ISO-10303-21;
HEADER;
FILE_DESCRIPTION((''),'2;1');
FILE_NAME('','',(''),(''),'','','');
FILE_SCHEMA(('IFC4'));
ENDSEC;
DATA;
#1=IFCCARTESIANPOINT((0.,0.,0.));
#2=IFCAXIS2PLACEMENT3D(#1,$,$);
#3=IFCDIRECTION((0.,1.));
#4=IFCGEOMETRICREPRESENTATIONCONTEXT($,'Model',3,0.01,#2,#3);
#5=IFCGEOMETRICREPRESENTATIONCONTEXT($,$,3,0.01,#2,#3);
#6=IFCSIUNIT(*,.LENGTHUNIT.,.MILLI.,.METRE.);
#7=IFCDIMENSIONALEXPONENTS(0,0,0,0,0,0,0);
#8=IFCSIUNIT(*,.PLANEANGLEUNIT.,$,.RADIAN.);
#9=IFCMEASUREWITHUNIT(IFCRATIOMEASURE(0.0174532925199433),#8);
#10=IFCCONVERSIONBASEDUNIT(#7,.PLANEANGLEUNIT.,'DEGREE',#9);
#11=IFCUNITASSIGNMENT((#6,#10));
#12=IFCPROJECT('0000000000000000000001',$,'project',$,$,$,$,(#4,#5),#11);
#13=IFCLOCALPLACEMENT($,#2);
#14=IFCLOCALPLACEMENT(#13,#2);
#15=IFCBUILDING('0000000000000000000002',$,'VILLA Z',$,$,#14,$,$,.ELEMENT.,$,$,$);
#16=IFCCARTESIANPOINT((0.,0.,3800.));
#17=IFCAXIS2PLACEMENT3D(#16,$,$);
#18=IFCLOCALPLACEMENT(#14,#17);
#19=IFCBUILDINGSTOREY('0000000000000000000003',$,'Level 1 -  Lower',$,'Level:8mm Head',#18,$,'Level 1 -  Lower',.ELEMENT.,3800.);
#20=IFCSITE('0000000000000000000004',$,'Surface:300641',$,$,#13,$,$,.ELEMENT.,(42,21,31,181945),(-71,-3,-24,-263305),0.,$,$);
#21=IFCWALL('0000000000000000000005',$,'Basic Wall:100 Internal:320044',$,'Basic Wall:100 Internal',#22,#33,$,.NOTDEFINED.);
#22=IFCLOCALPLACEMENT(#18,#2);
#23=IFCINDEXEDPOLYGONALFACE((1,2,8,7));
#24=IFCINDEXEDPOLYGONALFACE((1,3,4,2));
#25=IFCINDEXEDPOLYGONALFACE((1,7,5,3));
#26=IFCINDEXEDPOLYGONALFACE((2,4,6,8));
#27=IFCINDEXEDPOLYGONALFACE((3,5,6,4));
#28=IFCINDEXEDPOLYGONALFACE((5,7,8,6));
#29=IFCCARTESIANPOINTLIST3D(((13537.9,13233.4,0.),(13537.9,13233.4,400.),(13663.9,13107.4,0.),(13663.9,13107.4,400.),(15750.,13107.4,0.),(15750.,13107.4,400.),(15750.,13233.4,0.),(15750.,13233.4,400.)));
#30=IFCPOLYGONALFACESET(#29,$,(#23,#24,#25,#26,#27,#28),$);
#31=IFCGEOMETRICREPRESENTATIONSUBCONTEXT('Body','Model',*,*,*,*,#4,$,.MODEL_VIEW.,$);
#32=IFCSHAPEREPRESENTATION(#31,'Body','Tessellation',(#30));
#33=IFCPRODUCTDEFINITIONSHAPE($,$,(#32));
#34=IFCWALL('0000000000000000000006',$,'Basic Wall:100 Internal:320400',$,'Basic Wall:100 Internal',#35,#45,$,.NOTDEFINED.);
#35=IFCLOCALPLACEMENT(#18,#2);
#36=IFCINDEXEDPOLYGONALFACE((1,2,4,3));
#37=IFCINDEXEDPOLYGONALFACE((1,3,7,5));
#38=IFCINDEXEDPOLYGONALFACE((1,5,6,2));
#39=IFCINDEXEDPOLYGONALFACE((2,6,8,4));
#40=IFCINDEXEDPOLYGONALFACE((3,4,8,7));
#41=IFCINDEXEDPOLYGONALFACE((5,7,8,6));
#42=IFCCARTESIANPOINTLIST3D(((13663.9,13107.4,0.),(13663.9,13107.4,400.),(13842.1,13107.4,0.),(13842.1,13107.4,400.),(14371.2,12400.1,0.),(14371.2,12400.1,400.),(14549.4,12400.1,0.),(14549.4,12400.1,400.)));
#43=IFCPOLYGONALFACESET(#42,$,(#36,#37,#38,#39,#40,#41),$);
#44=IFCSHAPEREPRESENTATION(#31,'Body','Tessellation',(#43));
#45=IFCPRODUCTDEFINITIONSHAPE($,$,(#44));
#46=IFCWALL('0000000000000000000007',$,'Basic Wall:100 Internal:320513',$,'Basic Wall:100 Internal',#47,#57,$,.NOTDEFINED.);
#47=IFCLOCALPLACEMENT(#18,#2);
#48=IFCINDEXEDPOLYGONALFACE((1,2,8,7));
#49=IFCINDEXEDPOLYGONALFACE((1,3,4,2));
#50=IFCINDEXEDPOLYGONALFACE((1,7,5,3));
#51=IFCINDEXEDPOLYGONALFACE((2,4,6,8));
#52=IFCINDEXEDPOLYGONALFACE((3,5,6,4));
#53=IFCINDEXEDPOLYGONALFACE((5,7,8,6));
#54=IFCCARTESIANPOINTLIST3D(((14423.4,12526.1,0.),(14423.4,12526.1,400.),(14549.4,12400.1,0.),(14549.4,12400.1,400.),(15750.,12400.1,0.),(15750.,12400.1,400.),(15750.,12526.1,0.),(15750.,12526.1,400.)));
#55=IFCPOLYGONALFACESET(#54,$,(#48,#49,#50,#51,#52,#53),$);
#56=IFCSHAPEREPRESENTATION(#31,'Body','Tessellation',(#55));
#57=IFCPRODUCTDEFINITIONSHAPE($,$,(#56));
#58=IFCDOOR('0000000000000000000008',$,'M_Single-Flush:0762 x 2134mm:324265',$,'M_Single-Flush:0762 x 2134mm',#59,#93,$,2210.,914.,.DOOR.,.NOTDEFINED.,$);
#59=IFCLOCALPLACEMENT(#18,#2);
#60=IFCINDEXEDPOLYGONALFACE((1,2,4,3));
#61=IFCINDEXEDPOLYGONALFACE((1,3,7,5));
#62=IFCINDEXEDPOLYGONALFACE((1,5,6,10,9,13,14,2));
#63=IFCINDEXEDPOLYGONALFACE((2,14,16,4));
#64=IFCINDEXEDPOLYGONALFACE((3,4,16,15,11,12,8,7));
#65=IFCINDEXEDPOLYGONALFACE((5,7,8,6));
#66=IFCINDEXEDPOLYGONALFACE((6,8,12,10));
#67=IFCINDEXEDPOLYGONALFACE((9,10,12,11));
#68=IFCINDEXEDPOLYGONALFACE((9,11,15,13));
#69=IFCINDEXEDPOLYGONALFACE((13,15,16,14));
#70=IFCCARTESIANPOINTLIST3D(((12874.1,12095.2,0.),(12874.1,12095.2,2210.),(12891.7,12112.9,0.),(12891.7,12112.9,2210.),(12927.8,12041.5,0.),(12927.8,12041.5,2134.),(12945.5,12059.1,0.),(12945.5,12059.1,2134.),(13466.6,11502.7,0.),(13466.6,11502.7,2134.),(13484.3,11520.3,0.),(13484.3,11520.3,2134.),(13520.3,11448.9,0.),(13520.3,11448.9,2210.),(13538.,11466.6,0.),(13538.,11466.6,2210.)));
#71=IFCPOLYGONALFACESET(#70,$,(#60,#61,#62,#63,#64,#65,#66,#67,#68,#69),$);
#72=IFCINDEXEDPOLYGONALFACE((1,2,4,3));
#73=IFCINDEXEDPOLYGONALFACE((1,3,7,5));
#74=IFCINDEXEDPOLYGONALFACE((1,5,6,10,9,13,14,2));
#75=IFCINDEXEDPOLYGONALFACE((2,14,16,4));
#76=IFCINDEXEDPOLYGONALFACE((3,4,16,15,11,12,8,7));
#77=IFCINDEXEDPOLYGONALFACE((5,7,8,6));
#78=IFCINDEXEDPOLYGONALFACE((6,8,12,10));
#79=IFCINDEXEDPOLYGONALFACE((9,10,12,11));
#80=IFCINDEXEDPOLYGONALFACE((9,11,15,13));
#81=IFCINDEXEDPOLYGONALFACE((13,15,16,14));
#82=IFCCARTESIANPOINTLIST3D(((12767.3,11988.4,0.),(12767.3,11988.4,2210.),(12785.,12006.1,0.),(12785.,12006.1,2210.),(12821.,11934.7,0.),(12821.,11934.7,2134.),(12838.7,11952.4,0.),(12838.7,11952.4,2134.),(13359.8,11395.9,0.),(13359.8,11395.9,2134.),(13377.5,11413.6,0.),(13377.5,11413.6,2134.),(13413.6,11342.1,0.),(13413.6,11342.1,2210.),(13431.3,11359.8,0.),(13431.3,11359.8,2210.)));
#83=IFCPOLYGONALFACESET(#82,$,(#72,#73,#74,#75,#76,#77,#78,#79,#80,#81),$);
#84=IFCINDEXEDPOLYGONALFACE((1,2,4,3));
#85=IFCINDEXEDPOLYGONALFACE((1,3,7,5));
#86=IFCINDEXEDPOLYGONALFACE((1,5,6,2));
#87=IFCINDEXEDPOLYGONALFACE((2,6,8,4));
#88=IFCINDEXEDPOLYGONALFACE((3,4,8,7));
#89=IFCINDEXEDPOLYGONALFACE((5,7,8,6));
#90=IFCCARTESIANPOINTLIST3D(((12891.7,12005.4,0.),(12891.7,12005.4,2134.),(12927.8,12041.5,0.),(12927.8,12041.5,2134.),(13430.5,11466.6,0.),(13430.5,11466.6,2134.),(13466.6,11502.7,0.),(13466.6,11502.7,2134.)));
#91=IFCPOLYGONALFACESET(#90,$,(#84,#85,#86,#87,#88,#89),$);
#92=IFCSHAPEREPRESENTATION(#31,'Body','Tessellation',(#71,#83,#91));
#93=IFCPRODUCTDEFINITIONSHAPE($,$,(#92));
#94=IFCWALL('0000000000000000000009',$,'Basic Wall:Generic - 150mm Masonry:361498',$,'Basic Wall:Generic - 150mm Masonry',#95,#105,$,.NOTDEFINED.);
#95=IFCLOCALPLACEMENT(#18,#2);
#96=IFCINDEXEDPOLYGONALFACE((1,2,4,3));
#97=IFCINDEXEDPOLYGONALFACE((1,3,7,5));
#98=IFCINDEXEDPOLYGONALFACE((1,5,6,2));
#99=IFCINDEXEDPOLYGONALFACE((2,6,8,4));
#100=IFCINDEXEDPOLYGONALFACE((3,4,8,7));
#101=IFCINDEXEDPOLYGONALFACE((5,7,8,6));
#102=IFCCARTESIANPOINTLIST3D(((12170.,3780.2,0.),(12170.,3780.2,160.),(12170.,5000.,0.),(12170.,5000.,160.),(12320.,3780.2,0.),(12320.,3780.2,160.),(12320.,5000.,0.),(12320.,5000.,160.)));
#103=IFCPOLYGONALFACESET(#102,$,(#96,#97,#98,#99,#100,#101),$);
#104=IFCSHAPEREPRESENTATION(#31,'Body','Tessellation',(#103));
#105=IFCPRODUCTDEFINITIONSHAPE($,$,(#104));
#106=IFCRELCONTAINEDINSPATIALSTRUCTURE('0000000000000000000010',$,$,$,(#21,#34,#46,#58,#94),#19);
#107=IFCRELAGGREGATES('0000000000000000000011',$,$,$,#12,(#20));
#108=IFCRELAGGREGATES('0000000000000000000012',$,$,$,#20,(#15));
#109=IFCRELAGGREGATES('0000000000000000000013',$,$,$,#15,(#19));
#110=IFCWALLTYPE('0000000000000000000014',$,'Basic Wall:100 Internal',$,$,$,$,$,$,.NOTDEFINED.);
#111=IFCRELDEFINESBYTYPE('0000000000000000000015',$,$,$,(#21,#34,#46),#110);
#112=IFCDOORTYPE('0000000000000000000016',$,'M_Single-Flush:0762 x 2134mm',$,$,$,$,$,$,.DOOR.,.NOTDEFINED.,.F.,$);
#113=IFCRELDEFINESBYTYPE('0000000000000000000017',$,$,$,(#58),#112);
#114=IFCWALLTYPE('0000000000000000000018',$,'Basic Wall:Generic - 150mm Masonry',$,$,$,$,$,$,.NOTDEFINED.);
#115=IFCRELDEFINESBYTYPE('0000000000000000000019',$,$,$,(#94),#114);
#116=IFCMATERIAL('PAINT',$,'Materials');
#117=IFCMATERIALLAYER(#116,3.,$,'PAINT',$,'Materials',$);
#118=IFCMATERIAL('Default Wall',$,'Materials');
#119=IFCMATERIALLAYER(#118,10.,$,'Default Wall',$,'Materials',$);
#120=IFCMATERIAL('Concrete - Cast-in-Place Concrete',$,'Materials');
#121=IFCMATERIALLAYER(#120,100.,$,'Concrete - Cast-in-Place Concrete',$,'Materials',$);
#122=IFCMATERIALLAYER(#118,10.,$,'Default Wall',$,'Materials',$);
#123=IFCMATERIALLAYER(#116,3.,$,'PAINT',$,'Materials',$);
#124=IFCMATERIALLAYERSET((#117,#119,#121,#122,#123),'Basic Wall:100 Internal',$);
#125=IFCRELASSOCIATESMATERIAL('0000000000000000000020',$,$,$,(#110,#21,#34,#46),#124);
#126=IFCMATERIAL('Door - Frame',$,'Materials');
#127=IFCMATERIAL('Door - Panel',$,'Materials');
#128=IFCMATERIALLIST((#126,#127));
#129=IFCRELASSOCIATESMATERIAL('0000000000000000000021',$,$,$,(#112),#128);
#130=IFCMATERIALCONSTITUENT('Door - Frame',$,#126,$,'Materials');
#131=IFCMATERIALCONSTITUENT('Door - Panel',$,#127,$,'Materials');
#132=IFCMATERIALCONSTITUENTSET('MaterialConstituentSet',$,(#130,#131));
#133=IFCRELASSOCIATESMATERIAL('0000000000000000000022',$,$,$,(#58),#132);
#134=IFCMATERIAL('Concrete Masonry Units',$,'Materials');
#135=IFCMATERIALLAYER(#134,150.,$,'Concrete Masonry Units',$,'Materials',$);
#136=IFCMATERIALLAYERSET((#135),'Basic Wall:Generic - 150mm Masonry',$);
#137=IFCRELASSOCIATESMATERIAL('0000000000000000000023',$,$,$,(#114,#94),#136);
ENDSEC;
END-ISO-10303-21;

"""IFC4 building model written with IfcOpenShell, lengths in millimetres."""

from ifc_helpers import new_model, entity, si_unit, converted_unit, direction, frame, frame_2d, origin, origin_2d_with_axis, place, context, subcontext, project, spatial, polyline, rectangle, outline, extrude, clip, halfspace, source, transform, mapped, material, material_list, layer, layer_set, layer_usage, constituent, constituent_set, type_object, type_shapes, element, save


model = new_model("IFC4")

# Units and contexts
model_context = context("Model", 3, precision=0.01, world=origin(), true_north=direction((0.0, 1.0)))
context_of_model = context(None, 3, precision=0.01, world=origin(), true_north=direction((0.0, 1.0)))
body_context = subcontext(model_context, "Body", "Model", "MODEL_VIEW")
ifc_project = project(units=[si_unit("LENGTHUNIT", "METRE", prefix="MILLI"), converted_unit("PLANEANGLEUNIT", "DEGREE", entity("IfcRatioMeasure", 0.0174532925199433), si_unit("PLANEANGLEUNIT", "RADIAN"), dimensions=[0, 0, 0, 0, 0, 0, 0])], contexts=[model_context, context_of_model])

# Site, building, storey
site_placement = place(None, origin())
site = spatial("IfcSite", under=ifc_project, at=site_placement, Name="Surface:300641", CompositionType="ELEMENT", RefLatitude=(42, 21, 31, 181945), RefLongitude=(-71, -3, -24, -263305), RefElevation=0.0)
building_placement = place(site_placement, origin())
building = spatial("IfcBuilding", under=site, at=building_placement, Name="VILLA Z", CompositionType="ELEMENT")
storey_placement = place(building_placement, frame((0.0, 0.0, 3800.0)))
storey = spatial("IfcBuildingStorey", under=building, at=storey_placement, Name="Level 1 -  Lower", ObjectType="Level:8mm Head", LongName="Level 1 -  Lower", CompositionType="ELEMENT", Elevation=3800.0)

# Shared definitions
ifc_material_1 = material(Name="Concrete - Cast-in-Place Concrete", Category="Materials")

# Shared definitions
ifc_material_2 = material(Name="PAINT", Category="Materials")
ifc_material_3 = material(Name="Default Wall", Category="Materials")

# Walls
ifc_layer_1 = layer(ifc_material_2, 3.0, Name="PAINT", Category="Materials")
ifc_layer_2 = layer(ifc_material_3, 10.0, Name="Default Wall", Category="Materials")
ifc_layer_3 = layer(ifc_material_1, 100.0, Name="Concrete - Cast-in-Place Concrete", Category="Materials")
ifc_layer_4 = layer(ifc_material_3, 10.0, Name="Default Wall", Category="Materials")
ifc_layer_5 = layer(ifc_material_2, 3.0, Name="PAINT", Category="Materials")
ifc_layer_set_1 = layer_set([ifc_layer_1, ifc_layer_2, ifc_layer_3, ifc_layer_4, ifc_layer_5], Name="Basic Wall:100 Internal")
ifc_layer_usage_1 = layer_usage(ifc_layer_set_1, "AXIS2", "NEGATIVE", 63.0)
wall_type_1 = type_object("IfcWallType", Name="Basic Wall:100 Internal", PredefinedType="NOTDEFINED", material=ifc_layer_set_1)
wall_1_placement = place(storey_placement, frame((15750.0, 13170.4, 0.0), z_axis=(0.0, 0.0, 1.0), x_axis=(-1.0, 0.0, 0.0)))
element("IfcWall", 1, at=wall_1_placement, inside=storey, type_object=wall_type_1, material=ifc_layer_usage_1, Name="Basic Wall:100 Internal:320044", ObjectType="Basic Wall:100 Internal", PredefinedType="NOTDEFINED", context=body_context, shape_type="Clipping", body=[
    clip(extrude(outline(polyline([(2212.1, -63.0), (2086.1, 63.0), (1907.9, 63.0), (0.0, 63.0), (0.0, -63.0), (2212.1, -63.0)])), origin(), (0.0, 0.0, 1.0), 400.0), halfspace(origin(), True)),
])
ifc_layer_usage_2 = layer_usage(ifc_layer_set_1, "AXIS2", "NEGATIVE", 63.0)
wall_2_placement = place(storey_placement, frame((13708.5, 13152.0, 0.0), z_axis=(0.0, 0.0, 1.0), x_axis=(0.707107, -0.707107, 0.0)))
element("IfcWall", 2, at=wall_2_placement, inside=storey, type_object=wall_type_1, material=ifc_layer_usage_2, Name="Basic Wall:100 Internal:320400", ObjectType="Basic Wall:100 Internal", PredefinedType="NOTDEFINED", context=body_context, shape_type="Clipping", body=[
    clip(extrude(outline(polyline([(1000.3, -63.0), (1126.3, 63.0), (948.1, 63.0), (126.0, 63.0), (0.0, -63.0), (1000.3, -63.0)])), origin(), (0.0, 0.0, 1.0), 400.0), halfspace(origin(), True)),
])
ifc_layer_usage_3 = layer_usage(ifc_layer_set_1, "AXIS2", "NEGATIVE", 63.0)
wall_3_placement = place(storey_placement, frame((14423.4, 12463.1, 0.0)))
element("IfcWall", 3, at=wall_3_placement, inside=storey, type_object=wall_type_1, material=ifc_layer_usage_3, Name="Basic Wall:100 Internal:320513", ObjectType="Basic Wall:100 Internal", PredefinedType="NOTDEFINED", context=body_context, shape_type="Clipping", body=[
    clip(extrude(outline(polyline([(1326.6, -63.0), (1326.6, 63.0), (0.0, 63.0), (126.0, -63.0), (1326.6, -63.0)])), origin(), (0.0, 0.0, 1.0), 400.0), halfspace(origin(), True)),
])

# Door
ifc_material_4 = material(Name="Door - Frame", Category="Materials")
ifc_constituent_1 = constituent(ifc_material_4, Name="Door - Frame", Category="Materials")
ifc_material_5 = material(Name="Door - Panel", Category="Materials")
ifc_constituent_2 = constituent(ifc_material_5, Name="Door - Panel", Category="Materials")
ifc_constituent_set = constituent_set(constituents=[ifc_constituent_1, ifc_constituent_2], Name="MaterialConstituentSet")
ifc_material_list = material_list([ifc_material_4, ifc_material_5])
door_type = type_object("IfcDoorType", Name="M_Single-Flush:0762 x 2134mm", OperationType="NOTDEFINED", ParameterTakesPrecedence=False, PredefinedType="DOOR", material=ifc_material_list)
shared_shape_1 = source(origin(), body_context, "Body", "SweptSolid", [
    extrude(outline(polyline([(-457.0, -1124.0), (457.0, -1124.0), (457.0, 1086.0), (381.0, 1086.0), (381.0, -1048.0), (-381.0, -1048.0), (-381.0, 1086.0), (-457.0, 1086.0), (-457.0, -1124.0)])), frame((381.0, 126.0, 1086.0), z_axis=(0.0, 1.0, 0.0), x_axis=(1.0, 0.0, 0.0)), (0.0, 0.0, 1.0), 25.0),
    extrude(outline(polyline([(-1124.0, -457.0), (1086.0, -457.0), (1086.0, -381.0), (-1048.0, -381.0), (-1048.0, 381.0), (1086.0, 381.0), (1086.0, 457.0), (-1124.0, 457.0), (-1124.0, -457.0)])), frame((381.0, -25.0, 1086.0), z_axis=(0.0, 1.0, 0.0), x_axis=(0.0, 0.0, -1.0)), (0.0, 0.0, 1.0), 25.0),
    extrude(rectangle(XDim=51.0, YDim=762.0, at=origin_2d_with_axis()), frame((381.0, 100.5, 0.0), z_axis=(0.0, 0.0, 1.0), x_axis=(0.0, 1.0, 0.0)), (0.0, 0.0, 1.0), 2134.0),
])
type_shapes(door_type, [shared_shape_1])
door_placement = place(storey_placement, frame((12838.7, 11952.4, 0.0), z_axis=(0.0, 0.0, 1.0), x_axis=(0.707107, -0.707107, 0.0)))
element("IfcDoor", 4, at=door_placement, inside=storey, type_object=door_type, material=ifc_constituent_set, Name="M_Single-Flush:0762 x 2134mm:324265", ObjectType="M_Single-Flush:0762 x 2134mm", OperationType="NOTDEFINED", OverallHeight=2210.0, OverallWidth=914.0, PredefinedType="DOOR", context=body_context, shape_type="MappedRepresentation", body=[
    mapped(shared_shape_1, transform((0.0, 0.0, 0.0), scale=1.0)),
])

# Wall
ifc_material_6 = material(Name="Concrete Masonry Units", Category="Materials")
ifc_layer_6 = layer(ifc_material_6, 150.0, Name="Concrete Masonry Units", Category="Materials")
ifc_layer_set_2 = layer_set([ifc_layer_6], Name="Basic Wall:Generic - 150mm Masonry")
ifc_layer_usage_4 = layer_usage(ifc_layer_set_2, "AXIS2", "NEGATIVE", 75.0)
wall_type_2 = type_object("IfcWallType", Name="Basic Wall:Generic - 150mm Masonry", PredefinedType="NOTDEFINED", material=ifc_layer_set_2)
wall_4_placement = place(storey_placement, frame((12245.0, 5000.0, 0.0), z_axis=(0.0, 0.0, 1.0), x_axis=(0.0, -1.0, 0.0)))
element("IfcWall", 5, at=wall_4_placement, inside=storey, type_object=wall_type_2, material=ifc_layer_usage_4, Name="Basic Wall:Generic - 150mm Masonry:361498", ObjectType="Basic Wall:Generic - 150mm Masonry", PredefinedType="NOTDEFINED", context=body_context, shape_type="Clipping", body=[
    clip(extrude(rectangle(XDim=1219.8, YDim=150.0, at=frame_2d((609.9, 0.0), x_axis=(-1.0, 0.0))), origin(), (0.0, 0.0, 1.0), 160.0), halfspace(frame((0.0, 0.0, -3200.0)), True)),
])

save(model, "model.ifc")
